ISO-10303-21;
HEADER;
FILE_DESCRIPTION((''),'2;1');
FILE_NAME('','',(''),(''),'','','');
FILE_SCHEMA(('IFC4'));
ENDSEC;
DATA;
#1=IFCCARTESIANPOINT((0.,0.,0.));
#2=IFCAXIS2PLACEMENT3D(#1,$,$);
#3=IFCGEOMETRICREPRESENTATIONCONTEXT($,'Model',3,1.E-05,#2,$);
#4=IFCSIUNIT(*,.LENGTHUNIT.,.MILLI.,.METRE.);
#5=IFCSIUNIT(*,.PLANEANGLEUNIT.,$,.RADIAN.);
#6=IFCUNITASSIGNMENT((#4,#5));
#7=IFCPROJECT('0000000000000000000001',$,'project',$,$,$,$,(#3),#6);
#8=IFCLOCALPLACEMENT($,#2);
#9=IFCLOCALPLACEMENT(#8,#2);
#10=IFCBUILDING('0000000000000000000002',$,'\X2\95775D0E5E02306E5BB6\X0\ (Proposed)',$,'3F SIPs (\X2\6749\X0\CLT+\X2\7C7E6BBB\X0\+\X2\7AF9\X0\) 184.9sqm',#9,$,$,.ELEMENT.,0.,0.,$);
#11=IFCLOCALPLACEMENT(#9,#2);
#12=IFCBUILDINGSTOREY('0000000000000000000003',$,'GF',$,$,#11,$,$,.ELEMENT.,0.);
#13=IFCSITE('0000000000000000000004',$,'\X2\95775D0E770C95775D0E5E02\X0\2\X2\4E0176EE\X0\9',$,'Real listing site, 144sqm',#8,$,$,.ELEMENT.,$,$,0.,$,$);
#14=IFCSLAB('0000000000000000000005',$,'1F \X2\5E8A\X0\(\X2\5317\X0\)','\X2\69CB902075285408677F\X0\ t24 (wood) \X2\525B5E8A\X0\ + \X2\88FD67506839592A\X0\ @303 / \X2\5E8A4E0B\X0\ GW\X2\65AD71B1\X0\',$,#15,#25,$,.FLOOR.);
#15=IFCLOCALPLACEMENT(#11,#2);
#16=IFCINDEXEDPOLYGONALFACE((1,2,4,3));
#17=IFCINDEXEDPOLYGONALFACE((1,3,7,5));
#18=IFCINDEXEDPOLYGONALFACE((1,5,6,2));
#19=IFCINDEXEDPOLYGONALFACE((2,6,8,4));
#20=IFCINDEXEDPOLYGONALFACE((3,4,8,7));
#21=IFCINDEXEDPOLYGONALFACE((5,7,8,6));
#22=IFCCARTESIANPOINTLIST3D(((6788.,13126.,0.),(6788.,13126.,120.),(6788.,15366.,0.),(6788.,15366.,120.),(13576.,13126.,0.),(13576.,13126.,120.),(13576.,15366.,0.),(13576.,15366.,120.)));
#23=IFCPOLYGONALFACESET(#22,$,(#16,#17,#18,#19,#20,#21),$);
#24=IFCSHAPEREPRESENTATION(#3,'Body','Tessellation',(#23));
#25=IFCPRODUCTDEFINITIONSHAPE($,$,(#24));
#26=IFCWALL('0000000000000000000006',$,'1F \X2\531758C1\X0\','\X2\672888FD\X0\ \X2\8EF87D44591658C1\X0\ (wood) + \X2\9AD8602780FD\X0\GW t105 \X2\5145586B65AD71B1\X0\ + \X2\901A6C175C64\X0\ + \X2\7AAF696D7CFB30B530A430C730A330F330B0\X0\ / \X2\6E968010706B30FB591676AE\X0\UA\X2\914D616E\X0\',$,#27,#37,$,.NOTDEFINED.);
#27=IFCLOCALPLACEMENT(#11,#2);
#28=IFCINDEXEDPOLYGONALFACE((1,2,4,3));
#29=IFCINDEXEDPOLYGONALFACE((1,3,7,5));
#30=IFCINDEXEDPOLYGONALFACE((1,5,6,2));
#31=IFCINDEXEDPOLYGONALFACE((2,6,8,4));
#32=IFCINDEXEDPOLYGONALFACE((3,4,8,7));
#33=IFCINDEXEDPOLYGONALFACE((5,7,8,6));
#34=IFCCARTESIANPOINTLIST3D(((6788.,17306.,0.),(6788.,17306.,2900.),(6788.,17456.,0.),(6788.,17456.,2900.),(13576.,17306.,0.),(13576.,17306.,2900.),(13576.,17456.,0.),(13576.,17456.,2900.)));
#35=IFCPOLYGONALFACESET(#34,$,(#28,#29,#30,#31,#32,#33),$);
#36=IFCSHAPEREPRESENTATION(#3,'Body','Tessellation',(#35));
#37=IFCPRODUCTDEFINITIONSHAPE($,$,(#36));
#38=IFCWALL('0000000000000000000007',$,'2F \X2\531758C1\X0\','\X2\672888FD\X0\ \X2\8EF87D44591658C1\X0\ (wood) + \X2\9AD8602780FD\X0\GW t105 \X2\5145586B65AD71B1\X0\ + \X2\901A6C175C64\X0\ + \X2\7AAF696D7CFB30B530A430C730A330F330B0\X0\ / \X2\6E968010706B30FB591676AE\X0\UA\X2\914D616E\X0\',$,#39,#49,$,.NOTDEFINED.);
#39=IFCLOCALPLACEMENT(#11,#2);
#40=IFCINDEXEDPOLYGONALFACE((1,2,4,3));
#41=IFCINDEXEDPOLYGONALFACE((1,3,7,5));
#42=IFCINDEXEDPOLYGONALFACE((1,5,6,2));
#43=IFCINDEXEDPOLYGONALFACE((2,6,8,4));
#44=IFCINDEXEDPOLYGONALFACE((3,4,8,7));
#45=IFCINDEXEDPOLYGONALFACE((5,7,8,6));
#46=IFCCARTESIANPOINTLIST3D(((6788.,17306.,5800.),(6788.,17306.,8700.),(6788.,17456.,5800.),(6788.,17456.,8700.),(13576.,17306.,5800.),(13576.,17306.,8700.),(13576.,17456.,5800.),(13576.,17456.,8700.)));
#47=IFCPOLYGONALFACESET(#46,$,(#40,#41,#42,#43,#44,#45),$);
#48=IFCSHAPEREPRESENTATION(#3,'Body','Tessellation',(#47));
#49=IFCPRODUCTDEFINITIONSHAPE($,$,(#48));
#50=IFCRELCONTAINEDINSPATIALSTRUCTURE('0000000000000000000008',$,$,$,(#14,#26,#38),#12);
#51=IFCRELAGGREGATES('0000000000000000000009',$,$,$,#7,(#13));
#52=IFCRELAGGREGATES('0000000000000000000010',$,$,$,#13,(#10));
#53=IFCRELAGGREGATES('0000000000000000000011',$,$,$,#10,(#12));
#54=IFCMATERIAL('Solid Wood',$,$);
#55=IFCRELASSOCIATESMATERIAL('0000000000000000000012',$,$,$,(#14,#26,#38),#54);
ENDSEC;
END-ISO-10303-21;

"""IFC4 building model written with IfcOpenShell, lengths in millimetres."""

from ifc_helpers import new_model, si_unit, frame, frame_2d, origin, place, context, project, spatial, rectangle, extrude, material, element, save


model = new_model("IFC4")

# Units and contexts
model_context = context("Model", 3, precision=1e-05, world=origin())
ifc_project = project(units=[si_unit("LENGTHUNIT", "METRE", prefix="MILLI"), si_unit("PLANEANGLEUNIT", "RADIAN")], contexts=[model_context])

# Site, building, storey
site_placement = place(None, origin())
site = spatial("IfcSite", under=ifc_project, at=site_placement, Name="長崎県長崎市2丁目9", ObjectType="Real listing site, 144sqm", CompositionType="ELEMENT", RefElevation=0.0)
building_placement = place(site_placement, origin())
building = spatial("IfcBuilding", under=site, at=building_placement, Name="長崎市の家 (Proposed)", ObjectType="3F SIPs (杉CLT+籾殻+竹) 184.9sqm", CompositionType="ELEMENT", ElevationOfRefHeight=0.0, ElevationOfTerrain=0.0)
storey_placement = place(building_placement, origin())
storey = spatial("IfcBuildingStorey", under=building, at=storey_placement, Name="GF", CompositionType="ELEMENT", Elevation=0.0)

# Slab
ifc_material_1 = material(Name="Solid Wood")
slab_1_placement = place(storey_placement, frame((3394.0, 6563.0, 0.0)))
element("IfcSlab", 1, at=slab_1_placement, inside=storey, material=ifc_material_1, Name="1F 床(北)", Description="構造用合板 t24 (wood) 剛床 + 製材根太 @303 / 床下 GW断熱", PredefinedType="FLOOR", context=model_context, shape_type="SweptSolid", body=[
    extrude(rectangle(XDim=6788.0, YDim=2240.0, at=frame_2d((3394.0, 1120.0))), frame((3394.0, 6563.0, 0.0)), (0.0, 0.0, 1.0), 120.0),
])

# Wall
wall_1_placement = place(storey_placement, frame((3394.0, 8653.0, 0.0)))
element("IfcWall", 2, at=wall_1_placement, inside=storey, material=ifc_material_1, Name="1F 北壁", Description="木製 軸組外壁 (wood) + 高性能GW t105 充填断熱 + 通気層 + 窯業系サイディング / 準耐火・外皮UA配慮", PredefinedType="NOTDEFINED", context=model_context, shape_type="SweptSolid", body=[
    extrude(rectangle(XDim=6788.0, YDim=150.0, at=frame_2d((3394.0, 75.0))), frame((3394.0, 8653.0, 0.0)), (0.0, 0.0, 1.0), 2900.0),
])

# Wall
wall_2_placement = place(storey_placement, frame((3394.0, 8653.0, 2900.0)))
element("IfcWall", 3, at=wall_2_placement, inside=storey, material=ifc_material_1, Name="2F 北壁", Description="木製 軸組外壁 (wood) + 高性能GW t105 充填断熱 + 通気層 + 窯業系サイディング / 準耐火・外皮UA配慮", PredefinedType="NOTDEFINED", context=model_context, shape_type="SweptSolid", body=[
    extrude(rectangle(XDim=6788.0, YDim=150.0, at=frame_2d((3394.0, 75.0))), frame((3394.0, 8653.0, 2900.0)), (0.0, 0.0, 1.0), 2900.0),
])

save(model, "model.ifc")
